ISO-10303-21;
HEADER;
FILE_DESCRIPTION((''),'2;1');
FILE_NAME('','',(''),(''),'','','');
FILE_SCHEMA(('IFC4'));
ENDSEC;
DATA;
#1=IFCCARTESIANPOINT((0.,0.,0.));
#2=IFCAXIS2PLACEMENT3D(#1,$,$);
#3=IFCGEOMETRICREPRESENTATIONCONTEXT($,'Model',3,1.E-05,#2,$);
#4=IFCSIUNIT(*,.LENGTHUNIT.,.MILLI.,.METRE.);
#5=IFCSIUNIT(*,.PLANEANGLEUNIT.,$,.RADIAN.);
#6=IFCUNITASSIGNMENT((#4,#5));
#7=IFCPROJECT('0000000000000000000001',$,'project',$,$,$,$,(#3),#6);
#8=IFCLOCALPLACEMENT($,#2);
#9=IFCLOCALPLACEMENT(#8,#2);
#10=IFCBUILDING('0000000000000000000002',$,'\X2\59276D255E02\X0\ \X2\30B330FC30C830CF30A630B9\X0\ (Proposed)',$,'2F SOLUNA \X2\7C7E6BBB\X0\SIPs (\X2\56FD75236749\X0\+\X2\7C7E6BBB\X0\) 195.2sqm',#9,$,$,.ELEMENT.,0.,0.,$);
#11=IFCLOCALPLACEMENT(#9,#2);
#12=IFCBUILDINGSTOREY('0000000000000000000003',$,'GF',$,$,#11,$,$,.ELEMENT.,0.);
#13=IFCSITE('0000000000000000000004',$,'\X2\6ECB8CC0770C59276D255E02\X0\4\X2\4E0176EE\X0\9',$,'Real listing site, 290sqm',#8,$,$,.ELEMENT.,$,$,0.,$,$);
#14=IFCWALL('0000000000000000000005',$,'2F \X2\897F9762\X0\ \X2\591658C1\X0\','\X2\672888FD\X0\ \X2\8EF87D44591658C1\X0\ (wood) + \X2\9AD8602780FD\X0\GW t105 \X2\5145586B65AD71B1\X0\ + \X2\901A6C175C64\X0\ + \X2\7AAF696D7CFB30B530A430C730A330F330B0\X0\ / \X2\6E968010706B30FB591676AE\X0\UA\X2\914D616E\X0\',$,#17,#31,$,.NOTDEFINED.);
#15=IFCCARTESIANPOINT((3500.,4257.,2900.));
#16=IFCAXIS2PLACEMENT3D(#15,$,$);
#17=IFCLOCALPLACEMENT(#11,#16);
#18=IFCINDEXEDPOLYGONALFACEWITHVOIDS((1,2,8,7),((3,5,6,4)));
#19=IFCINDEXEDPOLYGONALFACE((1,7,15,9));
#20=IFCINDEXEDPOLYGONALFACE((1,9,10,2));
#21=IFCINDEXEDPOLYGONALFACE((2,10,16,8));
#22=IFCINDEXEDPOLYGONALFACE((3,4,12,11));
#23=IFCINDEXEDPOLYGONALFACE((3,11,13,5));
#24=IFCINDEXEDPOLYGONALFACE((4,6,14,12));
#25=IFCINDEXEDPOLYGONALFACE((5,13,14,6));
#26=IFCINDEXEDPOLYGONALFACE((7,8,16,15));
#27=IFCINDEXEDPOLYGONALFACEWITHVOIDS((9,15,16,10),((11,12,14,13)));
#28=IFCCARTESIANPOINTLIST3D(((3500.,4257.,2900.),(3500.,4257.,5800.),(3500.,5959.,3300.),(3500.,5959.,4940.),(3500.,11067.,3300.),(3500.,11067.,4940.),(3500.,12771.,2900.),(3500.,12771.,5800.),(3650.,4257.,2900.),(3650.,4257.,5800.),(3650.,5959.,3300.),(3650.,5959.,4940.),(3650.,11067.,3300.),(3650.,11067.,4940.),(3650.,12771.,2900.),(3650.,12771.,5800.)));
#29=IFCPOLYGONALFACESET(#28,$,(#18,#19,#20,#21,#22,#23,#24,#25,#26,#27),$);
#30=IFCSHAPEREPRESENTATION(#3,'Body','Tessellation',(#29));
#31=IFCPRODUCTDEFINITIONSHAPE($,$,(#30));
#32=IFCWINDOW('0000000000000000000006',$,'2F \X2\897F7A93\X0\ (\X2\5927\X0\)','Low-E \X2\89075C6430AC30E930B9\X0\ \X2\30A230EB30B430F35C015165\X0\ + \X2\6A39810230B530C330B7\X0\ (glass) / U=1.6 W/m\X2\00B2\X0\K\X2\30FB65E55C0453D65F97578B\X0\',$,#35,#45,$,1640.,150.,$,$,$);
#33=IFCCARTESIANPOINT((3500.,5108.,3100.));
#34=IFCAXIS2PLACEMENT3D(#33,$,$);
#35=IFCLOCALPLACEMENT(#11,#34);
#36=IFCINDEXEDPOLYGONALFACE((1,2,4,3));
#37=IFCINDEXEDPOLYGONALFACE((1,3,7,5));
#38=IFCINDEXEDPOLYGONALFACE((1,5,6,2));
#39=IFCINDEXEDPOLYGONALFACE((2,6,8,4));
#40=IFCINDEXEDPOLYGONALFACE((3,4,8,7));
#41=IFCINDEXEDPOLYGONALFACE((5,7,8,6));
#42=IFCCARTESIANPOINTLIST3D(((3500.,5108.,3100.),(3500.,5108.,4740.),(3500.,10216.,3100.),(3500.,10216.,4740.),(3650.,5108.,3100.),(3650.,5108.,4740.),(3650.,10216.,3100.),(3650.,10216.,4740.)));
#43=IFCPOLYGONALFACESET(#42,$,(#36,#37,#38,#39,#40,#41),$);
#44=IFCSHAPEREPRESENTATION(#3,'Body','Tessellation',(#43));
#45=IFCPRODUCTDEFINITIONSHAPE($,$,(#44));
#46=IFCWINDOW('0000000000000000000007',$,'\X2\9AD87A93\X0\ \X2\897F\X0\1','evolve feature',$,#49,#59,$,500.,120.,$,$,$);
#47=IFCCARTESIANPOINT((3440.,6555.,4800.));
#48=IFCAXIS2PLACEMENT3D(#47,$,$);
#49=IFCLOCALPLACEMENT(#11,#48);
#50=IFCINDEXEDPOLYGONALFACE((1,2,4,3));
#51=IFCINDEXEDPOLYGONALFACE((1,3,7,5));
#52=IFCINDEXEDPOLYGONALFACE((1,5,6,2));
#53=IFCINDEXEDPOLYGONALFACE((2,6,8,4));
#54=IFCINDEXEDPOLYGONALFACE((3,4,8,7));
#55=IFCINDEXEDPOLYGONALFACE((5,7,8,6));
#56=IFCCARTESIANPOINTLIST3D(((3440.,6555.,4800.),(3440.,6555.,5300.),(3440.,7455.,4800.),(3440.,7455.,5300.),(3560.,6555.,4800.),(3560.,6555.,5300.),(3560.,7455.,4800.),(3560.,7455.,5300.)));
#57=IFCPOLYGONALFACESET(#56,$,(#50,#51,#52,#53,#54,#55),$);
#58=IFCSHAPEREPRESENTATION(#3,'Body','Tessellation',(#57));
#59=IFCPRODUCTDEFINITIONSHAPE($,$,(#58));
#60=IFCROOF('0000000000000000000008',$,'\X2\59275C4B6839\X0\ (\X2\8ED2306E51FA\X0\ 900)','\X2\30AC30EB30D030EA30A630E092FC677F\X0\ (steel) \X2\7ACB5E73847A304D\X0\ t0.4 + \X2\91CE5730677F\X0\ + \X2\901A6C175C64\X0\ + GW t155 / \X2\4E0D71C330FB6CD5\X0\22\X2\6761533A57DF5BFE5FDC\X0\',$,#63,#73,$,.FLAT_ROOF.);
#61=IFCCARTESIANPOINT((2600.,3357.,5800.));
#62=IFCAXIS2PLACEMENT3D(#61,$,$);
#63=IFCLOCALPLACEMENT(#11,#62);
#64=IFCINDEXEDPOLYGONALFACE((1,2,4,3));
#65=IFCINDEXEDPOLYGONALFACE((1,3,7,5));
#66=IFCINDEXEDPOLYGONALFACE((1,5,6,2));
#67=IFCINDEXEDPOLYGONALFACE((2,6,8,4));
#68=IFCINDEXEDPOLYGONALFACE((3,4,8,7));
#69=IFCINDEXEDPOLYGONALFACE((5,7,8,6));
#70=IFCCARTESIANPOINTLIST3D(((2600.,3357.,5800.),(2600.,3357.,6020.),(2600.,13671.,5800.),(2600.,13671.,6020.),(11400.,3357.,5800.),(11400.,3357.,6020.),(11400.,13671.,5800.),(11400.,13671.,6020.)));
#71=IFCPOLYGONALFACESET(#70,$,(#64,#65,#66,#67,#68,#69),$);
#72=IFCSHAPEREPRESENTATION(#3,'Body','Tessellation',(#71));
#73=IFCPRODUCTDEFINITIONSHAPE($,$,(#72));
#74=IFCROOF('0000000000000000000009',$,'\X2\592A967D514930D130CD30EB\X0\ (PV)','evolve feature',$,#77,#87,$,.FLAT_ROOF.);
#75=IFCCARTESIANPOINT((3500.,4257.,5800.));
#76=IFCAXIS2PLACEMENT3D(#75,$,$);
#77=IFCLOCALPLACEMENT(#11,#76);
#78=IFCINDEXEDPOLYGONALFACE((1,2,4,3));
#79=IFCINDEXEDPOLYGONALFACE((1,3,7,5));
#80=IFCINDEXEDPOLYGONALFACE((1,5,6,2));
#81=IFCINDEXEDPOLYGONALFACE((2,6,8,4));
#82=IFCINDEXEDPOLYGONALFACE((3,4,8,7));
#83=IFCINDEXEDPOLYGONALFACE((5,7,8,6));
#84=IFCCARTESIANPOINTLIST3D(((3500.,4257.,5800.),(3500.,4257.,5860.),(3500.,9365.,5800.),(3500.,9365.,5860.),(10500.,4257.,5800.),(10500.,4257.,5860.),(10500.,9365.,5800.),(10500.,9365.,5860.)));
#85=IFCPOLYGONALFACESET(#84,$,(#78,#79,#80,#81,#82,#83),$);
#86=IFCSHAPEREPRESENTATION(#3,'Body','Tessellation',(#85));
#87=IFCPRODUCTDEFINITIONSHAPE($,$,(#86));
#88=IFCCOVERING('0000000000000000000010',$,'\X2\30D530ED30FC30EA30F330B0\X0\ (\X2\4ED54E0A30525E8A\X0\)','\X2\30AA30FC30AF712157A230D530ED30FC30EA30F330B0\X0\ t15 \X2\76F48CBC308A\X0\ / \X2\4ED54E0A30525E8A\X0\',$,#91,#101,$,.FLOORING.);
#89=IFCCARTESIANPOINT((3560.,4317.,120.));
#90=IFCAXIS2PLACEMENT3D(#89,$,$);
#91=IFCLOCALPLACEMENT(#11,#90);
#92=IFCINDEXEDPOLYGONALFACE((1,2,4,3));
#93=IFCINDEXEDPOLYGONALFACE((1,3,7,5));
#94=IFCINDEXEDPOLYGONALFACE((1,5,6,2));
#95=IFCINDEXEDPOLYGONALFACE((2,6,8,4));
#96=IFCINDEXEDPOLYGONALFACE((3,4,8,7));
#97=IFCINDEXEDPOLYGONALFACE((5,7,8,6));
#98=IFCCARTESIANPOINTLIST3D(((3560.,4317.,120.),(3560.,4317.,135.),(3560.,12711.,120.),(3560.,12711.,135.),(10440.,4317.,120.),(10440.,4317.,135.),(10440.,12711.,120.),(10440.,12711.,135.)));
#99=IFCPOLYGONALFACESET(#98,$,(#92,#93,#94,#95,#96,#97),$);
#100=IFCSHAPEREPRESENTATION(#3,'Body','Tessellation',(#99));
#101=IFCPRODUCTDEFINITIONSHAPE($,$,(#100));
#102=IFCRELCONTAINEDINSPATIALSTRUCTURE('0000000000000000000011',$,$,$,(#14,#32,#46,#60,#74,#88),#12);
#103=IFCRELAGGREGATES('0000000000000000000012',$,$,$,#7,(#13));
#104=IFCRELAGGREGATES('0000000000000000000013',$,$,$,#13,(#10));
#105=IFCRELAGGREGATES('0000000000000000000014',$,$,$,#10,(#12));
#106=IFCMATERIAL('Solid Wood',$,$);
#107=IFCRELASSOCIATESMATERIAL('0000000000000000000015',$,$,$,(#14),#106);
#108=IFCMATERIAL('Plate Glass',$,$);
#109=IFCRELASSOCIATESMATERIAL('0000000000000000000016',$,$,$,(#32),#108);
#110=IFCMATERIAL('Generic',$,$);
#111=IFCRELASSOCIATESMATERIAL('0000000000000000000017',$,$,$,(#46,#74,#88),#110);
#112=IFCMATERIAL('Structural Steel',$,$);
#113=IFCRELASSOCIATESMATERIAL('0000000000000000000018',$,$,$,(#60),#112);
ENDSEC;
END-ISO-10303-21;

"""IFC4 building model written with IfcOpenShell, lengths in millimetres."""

from ifc_helpers import new_model, si_unit, frame, frame_2d, origin, place, context, project, spatial, rectangle, extrude, material, element, fill, save


model = new_model("IFC4")

# Units and contexts
model_context = context("Model", 3, precision=1e-05, world=origin())
ifc_project = project(units=[si_unit("LENGTHUNIT", "METRE", prefix="MILLI"), si_unit("PLANEANGLEUNIT", "RADIAN")], contexts=[model_context])

# Site, building, storey
site_placement = place(None, origin())
site = spatial("IfcSite", under=ifc_project, at=site_placement, Name="滋賀県大津市4丁目9", ObjectType="Real listing site, 290sqm", CompositionType="ELEMENT", RefElevation=0.0)
building_placement = place(site_placement, origin())
building = spatial("IfcBuilding", under=site, at=building_placement, Name="大津市 コートハウス (Proposed)", ObjectType="2F SOLUNA 籾殻SIPs (国産杉+籾殻) 195.2sqm", CompositionType="ELEMENT", ElevationOfRefHeight=0.0, ElevationOfTerrain=0.0)
storey_placement = place(building_placement, origin())
storey = spatial("IfcBuildingStorey", under=building, at=storey_placement, Name="GF", CompositionType="ELEMENT", Elevation=0.0)

# Shared definitions
ifc_material_1 = material(Name="Solid Wood")

# Shared definitions
ifc_material_2 = material(Name="Plate Glass")
ifc_material_3 = material(Name="Generic")

# Wall, openings, windows
wall_1_placement = place(storey_placement, frame((3500.0, 4257.0, 2900.0)))
wall_1 = element("IfcWall", 1, at=wall_1_placement, inside=storey, material=ifc_material_1, Name="2F 西面 外壁", Description="木製 軸組外壁 (wood) + 高性能GW t105 充填断熱 + 通気層 + 窯業系サイディング / 準耐火・外皮UA配慮", PredefinedType="NOTDEFINED", context=model_context, shape_type="SweptSolid", body=[
    extrude(rectangle(XDim=150.0, YDim=8514.0, at=frame_2d((75.0, 4257.0))), frame((3500.0, 4257.0, 2900.0)), (0.0, 0.0, 1.0), 2900.0),
])
opening_1_placement = place(storey_placement, frame((3500.0, 5108.0, 3100.0)))
opening_1 = element("IfcOpeningElement", 2, at=opening_1_placement, cuts=wall_1, PredefinedType="NOTDEFINED", context=model_context, shape_type="SweptSolid", body=[
    extrude(rectangle(XDim=150.0, YDim=5108.0, at=frame_2d((75.0, 2554.0))), frame((3500.0, 5108.0, 3100.0)), (0.0, 0.0, 1.0), 1640.0),
])
opening_2_placement = place(storey_placement, frame((3440.0, 6555.0, 4800.0)))
opening_2 = element("IfcOpeningElement", 3, at=opening_2_placement, cuts=wall_1, PredefinedType="NOTDEFINED", context=model_context, shape_type="SweptSolid", body=[
    extrude(rectangle(XDim=120.0, YDim=900.0, at=frame_2d((60.0, 450.0))), frame((3440.0, 6555.0, 4800.0)), (0.0, 0.0, 1.0), 500.0),
])
window_1_placement = place(storey_placement, frame((3500.0, 5108.0, 3100.0)))
window_1 = element("IfcWindow", 4, at=window_1_placement, inside=storey, material=ifc_material_2, Name="2F 西窓 (大)", Description="Low-E 複層ガラス アルゴン封入 + 樹脂サッシ (glass) / U=1.6 W/m²K・日射取得型", OverallHeight=1640.0, OverallWidth=150.0, context=model_context, shape_type="SweptSolid", body=[
    extrude(rectangle(XDim=150.0, YDim=5108.0, at=frame_2d((75.0, 2554.0))), frame((3500.0, 5108.0, 3100.0)), (0.0, 0.0, 1.0), 1640.0),
])
fill(opening_1, window_1)
window_2_placement = place(storey_placement, frame((3440.0, 6555.0, 4800.0)))
window_2 = element("IfcWindow", 5, at=window_2_placement, inside=storey, material=ifc_material_3, Name="高窓 西1", Description="evolve feature", OverallHeight=500.0, OverallWidth=120.0, context=model_context, shape_type="SweptSolid", body=[
    extrude(rectangle(XDim=120.0, YDim=900.0, at=frame_2d((60.0, 450.0))), frame((3440.0, 6555.0, 4800.0)), (0.0, 0.0, 1.0), 500.0),
])
fill(opening_2, window_2)

# Roofs
ifc_material_4 = material(Name="Structural Steel")
roof_1_placement = place(storey_placement, frame((2600.0, 3357.0, 5800.0)))
element("IfcRoof", 6, at=roof_1_placement, inside=storey, material=ifc_material_4, Name="大屋根 (軒の出 900)", Description="ガルバリウム鋼板 (steel) 立平葺き t0.4 + 野地板 + 通気層 + GW t155 / 不燃・法22条区域対応", PredefinedType="FLAT_ROOF", context=model_context, shape_type="SweptSolid", body=[
    extrude(rectangle(XDim=8800.0, YDim=10314.0, at=frame_2d((4400.0, 5157.0))), frame((2600.0, 3357.0, 5800.0)), (0.0, 0.0, 1.0), 220.0),
])
roof_2_placement = place(storey_placement, frame((3500.0, 4257.0, 5800.0)))
element("IfcRoof", 7, at=roof_2_placement, inside=storey, material=ifc_material_3, Name="太陽光パネル (PV)", Description="evolve feature", PredefinedType="FLAT_ROOF", context=model_context, shape_type="SweptSolid", body=[
    extrude(rectangle(XDim=7000.0, YDim=5108.0, at=frame_2d((3500.0, 2554.0))), frame((3500.0, 4257.0, 5800.0)), (0.0, 0.0, 1.0), 60.0),
])

# Covering
covering_placement = place(storey_placement, frame((3560.0, 4317.0, 120.0)))
element("IfcCovering", 8, at=covering_placement, inside=storey, material=ifc_material_3, Name="フローリング (仕上げ床)", Description="オーク無垢フローリング t15 直貼り / 仕上げ床", PredefinedType="FLOORING", context=model_context, shape_type="SweptSolid", body=[
    extrude(rectangle(XDim=6880.0, YDim=8394.0, at=frame_2d((3440.0, 4197.0))), frame((3560.0, 4317.0, 120.0)), (0.0, 0.0, 1.0), 15.0),
])

save(model, "model.ifc")
